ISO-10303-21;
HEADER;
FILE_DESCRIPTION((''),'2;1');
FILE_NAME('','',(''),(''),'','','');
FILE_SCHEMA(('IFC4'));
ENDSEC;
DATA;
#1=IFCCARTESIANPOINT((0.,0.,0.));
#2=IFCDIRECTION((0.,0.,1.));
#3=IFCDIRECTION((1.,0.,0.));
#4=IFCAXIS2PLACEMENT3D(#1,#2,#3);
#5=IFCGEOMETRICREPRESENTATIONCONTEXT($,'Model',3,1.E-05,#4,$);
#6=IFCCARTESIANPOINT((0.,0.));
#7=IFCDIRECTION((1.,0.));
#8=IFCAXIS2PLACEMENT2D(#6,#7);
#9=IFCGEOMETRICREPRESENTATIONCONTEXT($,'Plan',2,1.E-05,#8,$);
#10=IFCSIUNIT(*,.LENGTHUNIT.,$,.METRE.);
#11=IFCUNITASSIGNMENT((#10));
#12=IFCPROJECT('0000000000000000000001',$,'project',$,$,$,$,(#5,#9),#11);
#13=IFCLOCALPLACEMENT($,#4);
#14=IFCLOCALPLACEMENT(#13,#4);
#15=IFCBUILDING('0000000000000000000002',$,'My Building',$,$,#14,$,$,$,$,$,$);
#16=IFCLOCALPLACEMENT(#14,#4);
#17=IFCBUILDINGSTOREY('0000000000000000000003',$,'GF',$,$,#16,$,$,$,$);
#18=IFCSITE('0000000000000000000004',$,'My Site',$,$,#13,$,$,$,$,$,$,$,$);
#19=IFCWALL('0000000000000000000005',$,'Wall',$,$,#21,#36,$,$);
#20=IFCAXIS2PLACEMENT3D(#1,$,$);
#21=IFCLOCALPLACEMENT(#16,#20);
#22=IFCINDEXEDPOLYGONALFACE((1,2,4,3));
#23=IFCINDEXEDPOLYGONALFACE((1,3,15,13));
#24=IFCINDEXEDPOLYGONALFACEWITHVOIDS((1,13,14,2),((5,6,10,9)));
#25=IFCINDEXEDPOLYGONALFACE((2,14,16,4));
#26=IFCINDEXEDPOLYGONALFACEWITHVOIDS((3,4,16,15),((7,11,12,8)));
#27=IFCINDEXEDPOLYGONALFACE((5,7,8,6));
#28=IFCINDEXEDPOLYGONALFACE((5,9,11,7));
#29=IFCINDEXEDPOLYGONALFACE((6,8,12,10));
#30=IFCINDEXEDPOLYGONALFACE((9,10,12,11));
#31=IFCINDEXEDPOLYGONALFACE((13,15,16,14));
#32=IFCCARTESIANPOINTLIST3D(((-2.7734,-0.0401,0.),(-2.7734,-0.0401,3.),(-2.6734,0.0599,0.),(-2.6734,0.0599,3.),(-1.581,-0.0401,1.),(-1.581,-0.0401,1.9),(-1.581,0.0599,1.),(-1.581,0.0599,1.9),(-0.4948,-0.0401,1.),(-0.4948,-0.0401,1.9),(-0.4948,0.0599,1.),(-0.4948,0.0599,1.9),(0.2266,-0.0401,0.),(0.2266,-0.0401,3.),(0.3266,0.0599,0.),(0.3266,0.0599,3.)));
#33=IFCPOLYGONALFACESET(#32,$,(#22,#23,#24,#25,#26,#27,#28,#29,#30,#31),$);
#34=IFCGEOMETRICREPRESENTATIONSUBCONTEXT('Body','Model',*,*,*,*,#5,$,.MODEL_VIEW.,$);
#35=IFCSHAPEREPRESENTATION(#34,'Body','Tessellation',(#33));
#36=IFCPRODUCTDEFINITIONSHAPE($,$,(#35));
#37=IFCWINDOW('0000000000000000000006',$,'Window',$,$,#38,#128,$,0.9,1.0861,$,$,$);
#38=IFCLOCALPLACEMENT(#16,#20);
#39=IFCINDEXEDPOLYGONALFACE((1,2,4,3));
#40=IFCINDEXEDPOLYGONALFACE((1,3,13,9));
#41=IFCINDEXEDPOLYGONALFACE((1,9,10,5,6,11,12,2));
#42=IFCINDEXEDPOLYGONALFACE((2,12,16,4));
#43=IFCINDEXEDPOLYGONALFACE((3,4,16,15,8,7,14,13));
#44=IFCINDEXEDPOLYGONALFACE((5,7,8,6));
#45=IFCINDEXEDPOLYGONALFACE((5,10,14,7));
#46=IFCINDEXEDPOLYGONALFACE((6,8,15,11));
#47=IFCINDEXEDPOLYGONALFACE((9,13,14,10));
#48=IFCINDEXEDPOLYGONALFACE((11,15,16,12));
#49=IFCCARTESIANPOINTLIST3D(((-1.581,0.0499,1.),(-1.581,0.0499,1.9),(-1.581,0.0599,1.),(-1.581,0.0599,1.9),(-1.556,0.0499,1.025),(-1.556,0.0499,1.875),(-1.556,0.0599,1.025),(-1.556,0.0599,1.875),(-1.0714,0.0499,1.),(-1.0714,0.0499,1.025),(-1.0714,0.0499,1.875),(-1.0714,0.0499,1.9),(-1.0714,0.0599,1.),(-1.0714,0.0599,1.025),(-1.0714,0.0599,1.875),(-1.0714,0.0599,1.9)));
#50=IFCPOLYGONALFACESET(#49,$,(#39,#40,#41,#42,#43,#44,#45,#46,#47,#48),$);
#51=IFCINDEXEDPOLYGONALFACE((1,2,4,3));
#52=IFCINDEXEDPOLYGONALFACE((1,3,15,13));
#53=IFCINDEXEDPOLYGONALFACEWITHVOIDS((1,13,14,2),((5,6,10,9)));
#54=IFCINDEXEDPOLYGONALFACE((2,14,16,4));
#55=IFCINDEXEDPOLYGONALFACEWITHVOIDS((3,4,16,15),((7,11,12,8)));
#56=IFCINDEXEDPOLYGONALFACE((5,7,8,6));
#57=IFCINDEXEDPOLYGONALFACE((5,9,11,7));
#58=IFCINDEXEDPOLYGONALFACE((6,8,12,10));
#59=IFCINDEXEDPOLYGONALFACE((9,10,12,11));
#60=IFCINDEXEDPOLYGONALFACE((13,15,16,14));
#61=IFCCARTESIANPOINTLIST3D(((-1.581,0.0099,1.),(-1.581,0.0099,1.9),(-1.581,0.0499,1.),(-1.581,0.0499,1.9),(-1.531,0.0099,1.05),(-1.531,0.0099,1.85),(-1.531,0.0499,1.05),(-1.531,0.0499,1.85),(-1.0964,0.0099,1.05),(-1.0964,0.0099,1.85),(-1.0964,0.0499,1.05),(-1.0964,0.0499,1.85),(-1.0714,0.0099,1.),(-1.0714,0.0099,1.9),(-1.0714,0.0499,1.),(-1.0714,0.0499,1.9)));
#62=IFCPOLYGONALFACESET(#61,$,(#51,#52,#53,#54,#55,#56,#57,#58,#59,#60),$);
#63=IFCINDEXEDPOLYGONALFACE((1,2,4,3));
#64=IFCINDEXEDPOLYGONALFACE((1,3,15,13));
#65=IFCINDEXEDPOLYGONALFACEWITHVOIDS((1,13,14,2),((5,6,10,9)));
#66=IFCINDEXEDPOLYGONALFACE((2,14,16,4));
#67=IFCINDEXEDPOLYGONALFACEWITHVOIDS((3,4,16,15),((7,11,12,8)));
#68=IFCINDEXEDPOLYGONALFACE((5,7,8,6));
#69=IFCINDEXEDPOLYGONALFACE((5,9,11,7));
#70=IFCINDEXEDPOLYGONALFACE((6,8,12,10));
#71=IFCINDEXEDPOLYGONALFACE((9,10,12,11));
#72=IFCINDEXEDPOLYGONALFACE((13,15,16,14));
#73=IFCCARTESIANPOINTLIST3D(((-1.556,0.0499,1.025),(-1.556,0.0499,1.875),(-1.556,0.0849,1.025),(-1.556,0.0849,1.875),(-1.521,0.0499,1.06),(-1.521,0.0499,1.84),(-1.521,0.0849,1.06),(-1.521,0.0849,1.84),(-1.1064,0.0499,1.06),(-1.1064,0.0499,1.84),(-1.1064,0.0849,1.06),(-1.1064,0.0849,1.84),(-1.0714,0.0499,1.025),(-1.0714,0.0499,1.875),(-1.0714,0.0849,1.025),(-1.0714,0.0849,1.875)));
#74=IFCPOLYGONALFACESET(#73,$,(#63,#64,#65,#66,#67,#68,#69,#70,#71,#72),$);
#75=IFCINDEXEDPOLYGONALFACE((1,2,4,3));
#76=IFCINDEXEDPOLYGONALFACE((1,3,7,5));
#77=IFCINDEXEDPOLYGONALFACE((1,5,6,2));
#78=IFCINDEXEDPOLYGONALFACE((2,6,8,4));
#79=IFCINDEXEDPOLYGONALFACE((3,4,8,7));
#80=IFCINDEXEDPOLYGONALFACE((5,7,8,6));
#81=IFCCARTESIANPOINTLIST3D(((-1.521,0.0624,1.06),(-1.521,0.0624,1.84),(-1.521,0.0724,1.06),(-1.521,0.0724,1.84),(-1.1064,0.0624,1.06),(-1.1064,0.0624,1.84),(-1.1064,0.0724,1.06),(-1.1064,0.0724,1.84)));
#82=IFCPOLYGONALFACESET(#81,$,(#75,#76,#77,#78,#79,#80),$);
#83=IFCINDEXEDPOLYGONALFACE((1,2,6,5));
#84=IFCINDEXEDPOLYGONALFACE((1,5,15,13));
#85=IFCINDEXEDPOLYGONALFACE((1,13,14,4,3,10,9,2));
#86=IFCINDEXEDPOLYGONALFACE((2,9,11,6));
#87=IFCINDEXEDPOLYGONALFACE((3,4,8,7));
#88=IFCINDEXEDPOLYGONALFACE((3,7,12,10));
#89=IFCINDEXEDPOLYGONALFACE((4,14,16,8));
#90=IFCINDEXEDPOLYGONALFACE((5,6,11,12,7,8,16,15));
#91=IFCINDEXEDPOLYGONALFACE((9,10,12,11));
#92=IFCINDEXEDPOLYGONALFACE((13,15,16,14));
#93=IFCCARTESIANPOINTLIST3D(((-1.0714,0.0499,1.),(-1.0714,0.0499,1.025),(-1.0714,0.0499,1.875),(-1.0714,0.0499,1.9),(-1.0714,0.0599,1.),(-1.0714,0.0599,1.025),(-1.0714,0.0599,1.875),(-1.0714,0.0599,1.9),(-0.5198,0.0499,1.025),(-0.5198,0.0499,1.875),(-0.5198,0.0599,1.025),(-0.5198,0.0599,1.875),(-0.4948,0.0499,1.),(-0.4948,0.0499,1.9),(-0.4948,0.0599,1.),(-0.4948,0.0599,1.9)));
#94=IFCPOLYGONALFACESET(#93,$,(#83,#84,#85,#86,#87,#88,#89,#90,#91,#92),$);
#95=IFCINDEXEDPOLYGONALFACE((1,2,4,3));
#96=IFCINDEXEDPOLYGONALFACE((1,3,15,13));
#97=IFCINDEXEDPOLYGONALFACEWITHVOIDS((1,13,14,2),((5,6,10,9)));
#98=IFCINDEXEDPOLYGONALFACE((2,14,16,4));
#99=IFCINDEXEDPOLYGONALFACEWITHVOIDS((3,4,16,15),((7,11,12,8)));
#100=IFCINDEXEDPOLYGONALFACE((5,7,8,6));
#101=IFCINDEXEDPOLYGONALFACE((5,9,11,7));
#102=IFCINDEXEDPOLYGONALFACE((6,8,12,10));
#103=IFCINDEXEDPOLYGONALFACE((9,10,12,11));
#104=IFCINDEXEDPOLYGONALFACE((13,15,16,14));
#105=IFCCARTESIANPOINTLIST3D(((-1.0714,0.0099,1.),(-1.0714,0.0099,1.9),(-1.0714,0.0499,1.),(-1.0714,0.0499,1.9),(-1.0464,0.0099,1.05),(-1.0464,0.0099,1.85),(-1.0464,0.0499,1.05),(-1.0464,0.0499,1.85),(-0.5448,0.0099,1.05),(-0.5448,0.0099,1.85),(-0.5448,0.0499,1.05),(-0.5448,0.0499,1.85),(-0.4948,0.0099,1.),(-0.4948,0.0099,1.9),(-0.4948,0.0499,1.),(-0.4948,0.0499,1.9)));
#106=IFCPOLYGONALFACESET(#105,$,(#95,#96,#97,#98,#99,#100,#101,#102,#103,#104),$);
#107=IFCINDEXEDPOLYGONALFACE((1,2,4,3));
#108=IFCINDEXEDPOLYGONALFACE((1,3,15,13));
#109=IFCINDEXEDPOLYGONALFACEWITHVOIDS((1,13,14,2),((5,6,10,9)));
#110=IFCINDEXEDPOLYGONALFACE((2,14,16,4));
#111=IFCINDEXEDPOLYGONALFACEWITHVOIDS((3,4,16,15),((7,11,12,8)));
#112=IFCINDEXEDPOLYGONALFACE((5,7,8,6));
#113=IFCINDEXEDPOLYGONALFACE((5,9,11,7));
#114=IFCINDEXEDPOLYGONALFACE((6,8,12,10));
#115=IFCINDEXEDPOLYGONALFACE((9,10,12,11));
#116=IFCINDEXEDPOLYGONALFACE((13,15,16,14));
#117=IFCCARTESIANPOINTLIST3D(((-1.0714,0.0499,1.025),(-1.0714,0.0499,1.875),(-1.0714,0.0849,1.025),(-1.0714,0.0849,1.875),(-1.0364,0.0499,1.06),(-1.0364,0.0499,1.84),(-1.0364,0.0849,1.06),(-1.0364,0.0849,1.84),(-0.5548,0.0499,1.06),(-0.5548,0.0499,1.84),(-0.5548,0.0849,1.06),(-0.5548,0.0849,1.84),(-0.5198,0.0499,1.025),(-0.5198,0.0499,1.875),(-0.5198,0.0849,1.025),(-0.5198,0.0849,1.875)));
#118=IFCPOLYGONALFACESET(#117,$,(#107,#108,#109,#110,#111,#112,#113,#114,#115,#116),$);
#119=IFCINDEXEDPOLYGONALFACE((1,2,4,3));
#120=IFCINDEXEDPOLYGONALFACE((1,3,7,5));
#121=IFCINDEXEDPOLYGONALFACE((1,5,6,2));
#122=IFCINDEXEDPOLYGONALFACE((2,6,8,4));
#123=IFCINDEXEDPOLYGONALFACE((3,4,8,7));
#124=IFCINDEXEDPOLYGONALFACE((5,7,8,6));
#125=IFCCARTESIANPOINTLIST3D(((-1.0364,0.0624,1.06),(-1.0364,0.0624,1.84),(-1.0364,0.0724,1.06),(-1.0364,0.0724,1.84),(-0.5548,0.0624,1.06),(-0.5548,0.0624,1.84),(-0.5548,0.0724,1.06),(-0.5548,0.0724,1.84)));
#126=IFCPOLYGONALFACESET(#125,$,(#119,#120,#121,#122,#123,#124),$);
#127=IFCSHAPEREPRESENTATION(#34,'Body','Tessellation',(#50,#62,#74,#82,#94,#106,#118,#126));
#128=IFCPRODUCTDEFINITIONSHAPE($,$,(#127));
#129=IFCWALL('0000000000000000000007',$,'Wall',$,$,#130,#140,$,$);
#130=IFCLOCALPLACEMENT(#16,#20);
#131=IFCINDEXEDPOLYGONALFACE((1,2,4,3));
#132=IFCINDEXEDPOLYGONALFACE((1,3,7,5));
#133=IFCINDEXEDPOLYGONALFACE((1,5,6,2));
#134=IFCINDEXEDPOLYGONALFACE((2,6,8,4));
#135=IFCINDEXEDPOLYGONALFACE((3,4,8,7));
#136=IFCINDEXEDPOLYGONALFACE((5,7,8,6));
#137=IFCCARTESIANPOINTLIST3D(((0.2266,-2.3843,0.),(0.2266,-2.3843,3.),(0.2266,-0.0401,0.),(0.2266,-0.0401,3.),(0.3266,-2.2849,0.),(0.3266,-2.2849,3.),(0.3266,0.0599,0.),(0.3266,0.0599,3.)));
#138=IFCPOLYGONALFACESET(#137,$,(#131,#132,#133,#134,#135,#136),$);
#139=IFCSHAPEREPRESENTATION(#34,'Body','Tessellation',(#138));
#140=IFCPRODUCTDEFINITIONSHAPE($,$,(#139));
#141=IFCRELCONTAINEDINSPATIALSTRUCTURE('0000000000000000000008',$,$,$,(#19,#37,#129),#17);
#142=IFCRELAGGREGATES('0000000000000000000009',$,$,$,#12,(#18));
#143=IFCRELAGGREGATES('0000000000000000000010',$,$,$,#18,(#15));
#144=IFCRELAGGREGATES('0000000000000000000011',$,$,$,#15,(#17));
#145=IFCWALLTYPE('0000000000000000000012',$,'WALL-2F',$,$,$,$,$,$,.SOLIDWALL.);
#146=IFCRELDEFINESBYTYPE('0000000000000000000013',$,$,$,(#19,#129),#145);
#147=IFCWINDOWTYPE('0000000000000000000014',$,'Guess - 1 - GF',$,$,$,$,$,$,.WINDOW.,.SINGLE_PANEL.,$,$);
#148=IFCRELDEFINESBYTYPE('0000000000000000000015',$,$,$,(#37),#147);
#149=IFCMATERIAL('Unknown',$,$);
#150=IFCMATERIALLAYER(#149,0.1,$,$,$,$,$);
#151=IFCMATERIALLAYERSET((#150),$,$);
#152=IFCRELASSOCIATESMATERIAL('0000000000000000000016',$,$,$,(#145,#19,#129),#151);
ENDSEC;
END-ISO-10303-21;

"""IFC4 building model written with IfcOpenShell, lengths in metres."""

from ifc_helpers import new_model, entity, si_unit, frame, origin_with_axes, origin_2d_with_axis, place, context, subcontext, project, spatial, line, indexed_curve, outline, extrude, shape, source, transform, mapped, material, layer, layer_set, layer_usage, type_object, type_shapes, element, fill, save


model = new_model("IFC4")

# Units and contexts
model_context = context("Model", 3, precision=1e-05, world=origin_with_axes())
plan_context = context("Plan", 2, precision=1e-05, world=origin_2d_with_axis())
body_context_1 = subcontext(model_context, "Body", "Model", "MODEL_VIEW")
body_context_2 = subcontext(plan_context, "Body", "Plan", "PLAN_VIEW")
ifc_project = project(units=[si_unit("LENGTHUNIT", "METRE")], contexts=[model_context, plan_context])

# Site, building, storey
site_placement = place(None, origin_with_axes())
site = spatial("IfcSite", under=ifc_project, at=site_placement, Name="My Site")
building_placement = place(site_placement, origin_with_axes())
building = spatial("IfcBuilding", under=site, at=building_placement, Name="My Building")
storey_placement = place(building_placement, origin_with_axes())
storey = spatial("IfcBuildingStorey", under=building, at=storey_placement, Name="GF")

# Shared definitions
ifc_material = material(Name="Unknown")

# Shared definitions
ifc_layer_1 = layer(ifc_material, 0.1)
ifc_layer_set_1 = layer_set([ifc_layer_1])
wall_type_1 = type_object("IfcWallType", Name="WALL-2F", PredefinedType="SOLIDWALL", material=ifc_layer_set_1)

# Wall, opening, window
ifc_layer_usage_1 = layer_usage(ifc_layer_set_1, "AXIS2", "POSITIVE", 0.0)
wall_1_placement = place(storey_placement, frame((-2.7734, -0.0401, 0.0), z_axis=(0.0, 0.0, 1.0), x_axis=(1.0, 0.0, 0.0)))
wall_1 = element("IfcWall", 1, at=wall_1_placement, inside=storey, type_object=wall_type_1, material=ifc_layer_usage_1, Name="Wall", context=body_context_1, shape_type="SweptSolid", body=[
    extrude(outline(indexed_curve([(0.0, 0.0), (0.1, 0.1), (3.1, 0.1), (3.0, 0.0)], segments=[line(1, 2, 3, 4, 1)])), origin_with_axes(), (0.0, 0.0, 1.0), 3.0),
])
shared_shape_1 = source(origin_with_axes(), body_context_1, "Body", "SweptSolid", [
    extrude(outline(indexed_curve([(0.0, 0.0), (1.0861, 0.0), (1.0861, 0.9), (0.0, 0.9)], segments=[line(1, 2, 3, 4, 1)])), frame((0.0, -0.6, 0.0), z_axis=(0.0, -1.0, 0.0), x_axis=(1.0, 0.0, 0.0)), (0.0, 0.0, -1.0), 1.2),
])
opening_1_placement = place(wall_1_placement, frame((1.1924, 0.0, 1.0), z_axis=(0.0, 0.0, 1.0), x_axis=(1.0, 0.0, 0.0)))
opening_1 = element("IfcOpeningElement", 2, at=opening_1_placement, cuts=wall_1, PredefinedType="OPENING", context=body_context_1, shape_type="MappedRepresentation", body=[
    mapped(shared_shape_1, transform((0.0, 0.0, 0.0), x_axis=(1.0, 0.0, 0.0), y_axis=(0.0, 1.0, 0.0), z_axis=(0.0, 0.0, 1.0), scale=1.0)),
])
window_type_1 = type_object("IfcWindowType", Name="Guess - 1 - GF", PartitioningType="SINGLE_PANEL", PredefinedType="WINDOW")
shared_shape_2 = source(origin_with_axes(), body_context_1, "Body", "SweptSolid", [
    extrude(outline(indexed_curve([(0.5096, 0.0), (0.0, 0.0), (0.0, 0.9), (0.5096, 0.9), (0.5096, 0.875), (0.025, 0.875), (0.025, 0.025), (0.5096, 0.025)], segments=[line(1, 2, 3, 4, 5, 6, 7, 8, 1)])), frame((0.0, 0.09, 0.0), z_axis=(0.0, -1.0, 0.0), x_axis=(1.0, 0.0, 0.0)), (0.0, 0.0, -1.0), 0.01),
    extrude(outline(indexed_curve([(0.0, 0.0), (0.5096, 0.0), (0.5096, 0.9), (0.0, 0.9)], segments=[line(1, 2, 3, 4, 1)]), holes=[indexed_curve([(0.05, 0.05), (0.4846, 0.05), (0.4846, 0.85), (0.05, 0.85)], segments=[line(1, 2, 3, 4, 1)])]), frame((0.0, 0.05, 0.0), z_axis=(0.0, -1.0, 0.0), x_axis=(1.0, 0.0, 0.0)), (0.0, 0.0, -1.0), 0.04),
    extrude(outline(indexed_curve([(0.0, 0.0), (0.4846, 0.0), (0.4846, 0.85), (0.0, 0.85)], segments=[line(1, 2, 3, 4, 1)]), holes=[indexed_curve([(0.035, 0.035), (0.4496, 0.035), (0.4496, 0.815), (0.035, 0.815)], segments=[line(1, 2, 3, 4, 1)])]), frame((0.025, 0.09, 0.025), z_axis=(0.0, -1.0, 0.0), x_axis=(1.0, 0.0, 0.0)), (0.0, 0.0, -1.0), 0.035),
    extrude(outline(indexed_curve([(0.035, 0.035), (0.4496, 0.035), (0.4496, 0.815), (0.035, 0.815)], segments=[line(1, 2, 3, 4, 1)])), frame((0.025, 0.1025, 0.025), z_axis=(0.0, -1.0, 0.0), x_axis=(1.0, 0.0, 0.0)), (0.0, 0.0, -1.0), 0.01),
    extrude(outline(indexed_curve([(0.0, 0.9), (0.5766, 0.9), (0.5766, 0.0), (0.0, 0.0), (0.0, 0.025), (0.5516, 0.025), (0.5516, 0.875), (0.0, 0.875)], segments=[line(1, 2, 3, 4, 5, 6, 7, 8, 1)])), frame((0.5096, 0.09, 0.0), z_axis=(0.0, -1.0, 0.0), x_axis=(1.0, 0.0, 0.0)), (0.0, 0.0, -1.0), 0.01),
    extrude(outline(indexed_curve([(0.0, 0.0), (0.5766, 0.0), (0.5766, 0.9), (0.0, 0.9)], segments=[line(1, 2, 3, 4, 1)]), holes=[indexed_curve([(0.025, 0.05), (0.5266, 0.05), (0.5266, 0.85), (0.025, 0.85)], segments=[line(1, 2, 3, 4, 1)])]), frame((0.5096, 0.05, 0.0), z_axis=(0.0, -1.0, 0.0), x_axis=(1.0, 0.0, 0.0)), (0.0, 0.0, -1.0), 0.04),
    extrude(outline(indexed_curve([(0.0, 0.0), (0.5516, 0.0), (0.5516, 0.85), (0.0, 0.85)], segments=[line(1, 2, 3, 4, 1)]), holes=[indexed_curve([(0.035, 0.035), (0.5166, 0.035), (0.5166, 0.815), (0.035, 0.815)], segments=[line(1, 2, 3, 4, 1)])]), frame((0.5096, 0.09, 0.025), z_axis=(0.0, -1.0, 0.0), x_axis=(1.0, 0.0, 0.0)), (0.0, 0.0, -1.0), 0.035),
    extrude(outline(indexed_curve([(0.035, 0.035), (0.5166, 0.035), (0.5166, 0.815), (0.035, 0.815)], segments=[line(1, 2, 3, 4, 1)])), frame((0.5096, 0.1025, 0.025), z_axis=(0.0, -1.0, 0.0), x_axis=(1.0, 0.0, 0.0)), (0.0, 0.0, -1.0), 0.01),
])
shared_shape_3 = source(origin_with_axes(), body_context_2, "Body", "Curve2D", [
    entity("IfcIndexedPolyCurve", entity("IfcCartesianPointList2D", [[0.05, 0.05], [0.4846, 0.05]])),
    entity("IfcIndexedPolyCurve", entity("IfcCartesianPointList2D", [[0.0, 0.1], [0.025, 0.1], [0.025, 0.09], [0.05, 0.09], [0.05, 0.05], [0.0, 0.05]]), [entity("IfcLineIndex", [1, 2, 3, 4, 5, 6, 1])]),
    entity("IfcIndexedPolyCurve", entity("IfcCartesianPointList2D", [[0.5096, 0.1], [0.5096, 0.1], [0.5096, 0.09], [0.4846, 0.09], [0.4846, 0.05], [0.5096, 0.05]])),
    entity("IfcIndexedPolyCurve", entity("IfcCartesianPointList2D", [[0.025, 0.09], [0.06, 0.09], [0.06, 0.125], [0.025, 0.125]]), [entity("IfcLineIndex", [1, 2, 3, 4, 1])]),
    entity("IfcIndexedPolyCurve", entity("IfcCartesianPointList2D", [[0.5096, 0.09], [0.4746, 0.09], [0.4746, 0.125], [0.5096, 0.125]]), [entity("IfcLineIndex", [1, 2, 3, 4, 1])]),
    entity("IfcIndexedPolyCurve", entity("IfcCartesianPointList2D", [[0.06, 0.09], [0.4746, 0.09]])),
    entity("IfcIndexedPolyCurve", entity("IfcCartesianPointList2D", [[0.06, 0.125], [0.4746, 0.125]])),
    entity("IfcIndexedPolyCurve", entity("IfcCartesianPointList2D", [[0.06, 0.1075], [0.4746, 0.1075]])),
    entity("IfcIndexedPolyCurve", entity("IfcCartesianPointList2D", [[0.5346, 0.05], [1.0361, 0.05]])),
    entity("IfcIndexedPolyCurve", entity("IfcCartesianPointList2D", [[0.5096, 0.1], [0.5096, 0.1], [0.5096, 0.09], [0.5346, 0.09], [0.5346, 0.05], [0.5096, 0.05]])),
    entity("IfcIndexedPolyCurve", entity("IfcCartesianPointList2D", [[1.0861, 0.1], [1.0611, 0.1], [1.0611, 0.09], [1.0361, 0.09], [1.0361, 0.05], [1.0861, 0.05]]), [entity("IfcLineIndex", [1, 2, 3, 4, 5, 6, 1])]),
    entity("IfcIndexedPolyCurve", entity("IfcCartesianPointList2D", [[0.5096, 0.09], [0.5446, 0.09], [0.5446, 0.125], [0.5096, 0.125]]), [entity("IfcLineIndex", [1, 2, 3, 4, 1])]),
    entity("IfcIndexedPolyCurve", entity("IfcCartesianPointList2D", [[1.0611, 0.09], [1.0261, 0.09], [1.0261, 0.125], [1.0611, 0.125]]), [entity("IfcLineIndex", [1, 2, 3, 4, 1])]),
    entity("IfcIndexedPolyCurve", entity("IfcCartesianPointList2D", [[0.5446, 0.09], [1.0261, 0.09]])),
    entity("IfcIndexedPolyCurve", entity("IfcCartesianPointList2D", [[0.5446, 0.125], [1.0261, 0.125]])),
    entity("IfcIndexedPolyCurve", entity("IfcCartesianPointList2D", [[0.5446, 0.1075], [1.0261, 0.1075]])),
])
type_shapes(window_type_1, [shared_shape_2, shared_shape_3])
window_1_placement = place(opening_1_placement, frame((0.0, 0.0, 0.0), z_axis=(0.0, 0.0, 1.0), x_axis=(1.0, 0.0, 0.0)))
window_1 = element("IfcWindow", 3, at=window_1_placement, inside=storey, type_object=window_type_1, Name="Window", OverallHeight=0.9, OverallWidth=1.0861, shapes=[
    shape(body_context_1, "Body", "MappedRepresentation", [mapped(shared_shape_2, transform((0.0, 0.0, 0.0), x_axis=(1.0, 0.0, 0.0), y_axis=(0.0, 1.0, 0.0), z_axis=(0.0, 0.0, 1.0), scale=1.0))]),
    shape(body_context_2, "Body", "MappedRepresentation", [mapped(shared_shape_3, transform((0.0, 0.0, 0.0), x_axis=(1.0, 0.0, 0.0), y_axis=(0.0, 1.0, 0.0), z_axis=(0.0, 0.0, 1.0), scale=1.0))]),
])
fill(opening_1, window_1)

# Wall
ifc_layer_usage_2 = layer_usage(ifc_layer_set_1, "AXIS2", "POSITIVE", 0.0)
wall_2_placement = place(storey_placement, frame((0.2266, -0.0401, 0.0), z_axis=(0.0, 0.0, 1.0), x_axis=(0.0, -1.0, 0.0)))
element("IfcWall", 4, at=wall_2_placement, inside=storey, type_object=wall_type_1, material=ifc_layer_usage_2, Name="Wall", context=body_context_1, shape_type="SweptSolid", body=[
    extrude(outline(indexed_curve([(0.0, 0.0), (-0.1, 0.1), (2.2448, 0.1), (2.3442, 0.0)], segments=[line(1, 2, 3, 4, 1)])), origin_with_axes(), (0.0, 0.0, 1.0), 3.0),
])

save(model, "model.ifc")
